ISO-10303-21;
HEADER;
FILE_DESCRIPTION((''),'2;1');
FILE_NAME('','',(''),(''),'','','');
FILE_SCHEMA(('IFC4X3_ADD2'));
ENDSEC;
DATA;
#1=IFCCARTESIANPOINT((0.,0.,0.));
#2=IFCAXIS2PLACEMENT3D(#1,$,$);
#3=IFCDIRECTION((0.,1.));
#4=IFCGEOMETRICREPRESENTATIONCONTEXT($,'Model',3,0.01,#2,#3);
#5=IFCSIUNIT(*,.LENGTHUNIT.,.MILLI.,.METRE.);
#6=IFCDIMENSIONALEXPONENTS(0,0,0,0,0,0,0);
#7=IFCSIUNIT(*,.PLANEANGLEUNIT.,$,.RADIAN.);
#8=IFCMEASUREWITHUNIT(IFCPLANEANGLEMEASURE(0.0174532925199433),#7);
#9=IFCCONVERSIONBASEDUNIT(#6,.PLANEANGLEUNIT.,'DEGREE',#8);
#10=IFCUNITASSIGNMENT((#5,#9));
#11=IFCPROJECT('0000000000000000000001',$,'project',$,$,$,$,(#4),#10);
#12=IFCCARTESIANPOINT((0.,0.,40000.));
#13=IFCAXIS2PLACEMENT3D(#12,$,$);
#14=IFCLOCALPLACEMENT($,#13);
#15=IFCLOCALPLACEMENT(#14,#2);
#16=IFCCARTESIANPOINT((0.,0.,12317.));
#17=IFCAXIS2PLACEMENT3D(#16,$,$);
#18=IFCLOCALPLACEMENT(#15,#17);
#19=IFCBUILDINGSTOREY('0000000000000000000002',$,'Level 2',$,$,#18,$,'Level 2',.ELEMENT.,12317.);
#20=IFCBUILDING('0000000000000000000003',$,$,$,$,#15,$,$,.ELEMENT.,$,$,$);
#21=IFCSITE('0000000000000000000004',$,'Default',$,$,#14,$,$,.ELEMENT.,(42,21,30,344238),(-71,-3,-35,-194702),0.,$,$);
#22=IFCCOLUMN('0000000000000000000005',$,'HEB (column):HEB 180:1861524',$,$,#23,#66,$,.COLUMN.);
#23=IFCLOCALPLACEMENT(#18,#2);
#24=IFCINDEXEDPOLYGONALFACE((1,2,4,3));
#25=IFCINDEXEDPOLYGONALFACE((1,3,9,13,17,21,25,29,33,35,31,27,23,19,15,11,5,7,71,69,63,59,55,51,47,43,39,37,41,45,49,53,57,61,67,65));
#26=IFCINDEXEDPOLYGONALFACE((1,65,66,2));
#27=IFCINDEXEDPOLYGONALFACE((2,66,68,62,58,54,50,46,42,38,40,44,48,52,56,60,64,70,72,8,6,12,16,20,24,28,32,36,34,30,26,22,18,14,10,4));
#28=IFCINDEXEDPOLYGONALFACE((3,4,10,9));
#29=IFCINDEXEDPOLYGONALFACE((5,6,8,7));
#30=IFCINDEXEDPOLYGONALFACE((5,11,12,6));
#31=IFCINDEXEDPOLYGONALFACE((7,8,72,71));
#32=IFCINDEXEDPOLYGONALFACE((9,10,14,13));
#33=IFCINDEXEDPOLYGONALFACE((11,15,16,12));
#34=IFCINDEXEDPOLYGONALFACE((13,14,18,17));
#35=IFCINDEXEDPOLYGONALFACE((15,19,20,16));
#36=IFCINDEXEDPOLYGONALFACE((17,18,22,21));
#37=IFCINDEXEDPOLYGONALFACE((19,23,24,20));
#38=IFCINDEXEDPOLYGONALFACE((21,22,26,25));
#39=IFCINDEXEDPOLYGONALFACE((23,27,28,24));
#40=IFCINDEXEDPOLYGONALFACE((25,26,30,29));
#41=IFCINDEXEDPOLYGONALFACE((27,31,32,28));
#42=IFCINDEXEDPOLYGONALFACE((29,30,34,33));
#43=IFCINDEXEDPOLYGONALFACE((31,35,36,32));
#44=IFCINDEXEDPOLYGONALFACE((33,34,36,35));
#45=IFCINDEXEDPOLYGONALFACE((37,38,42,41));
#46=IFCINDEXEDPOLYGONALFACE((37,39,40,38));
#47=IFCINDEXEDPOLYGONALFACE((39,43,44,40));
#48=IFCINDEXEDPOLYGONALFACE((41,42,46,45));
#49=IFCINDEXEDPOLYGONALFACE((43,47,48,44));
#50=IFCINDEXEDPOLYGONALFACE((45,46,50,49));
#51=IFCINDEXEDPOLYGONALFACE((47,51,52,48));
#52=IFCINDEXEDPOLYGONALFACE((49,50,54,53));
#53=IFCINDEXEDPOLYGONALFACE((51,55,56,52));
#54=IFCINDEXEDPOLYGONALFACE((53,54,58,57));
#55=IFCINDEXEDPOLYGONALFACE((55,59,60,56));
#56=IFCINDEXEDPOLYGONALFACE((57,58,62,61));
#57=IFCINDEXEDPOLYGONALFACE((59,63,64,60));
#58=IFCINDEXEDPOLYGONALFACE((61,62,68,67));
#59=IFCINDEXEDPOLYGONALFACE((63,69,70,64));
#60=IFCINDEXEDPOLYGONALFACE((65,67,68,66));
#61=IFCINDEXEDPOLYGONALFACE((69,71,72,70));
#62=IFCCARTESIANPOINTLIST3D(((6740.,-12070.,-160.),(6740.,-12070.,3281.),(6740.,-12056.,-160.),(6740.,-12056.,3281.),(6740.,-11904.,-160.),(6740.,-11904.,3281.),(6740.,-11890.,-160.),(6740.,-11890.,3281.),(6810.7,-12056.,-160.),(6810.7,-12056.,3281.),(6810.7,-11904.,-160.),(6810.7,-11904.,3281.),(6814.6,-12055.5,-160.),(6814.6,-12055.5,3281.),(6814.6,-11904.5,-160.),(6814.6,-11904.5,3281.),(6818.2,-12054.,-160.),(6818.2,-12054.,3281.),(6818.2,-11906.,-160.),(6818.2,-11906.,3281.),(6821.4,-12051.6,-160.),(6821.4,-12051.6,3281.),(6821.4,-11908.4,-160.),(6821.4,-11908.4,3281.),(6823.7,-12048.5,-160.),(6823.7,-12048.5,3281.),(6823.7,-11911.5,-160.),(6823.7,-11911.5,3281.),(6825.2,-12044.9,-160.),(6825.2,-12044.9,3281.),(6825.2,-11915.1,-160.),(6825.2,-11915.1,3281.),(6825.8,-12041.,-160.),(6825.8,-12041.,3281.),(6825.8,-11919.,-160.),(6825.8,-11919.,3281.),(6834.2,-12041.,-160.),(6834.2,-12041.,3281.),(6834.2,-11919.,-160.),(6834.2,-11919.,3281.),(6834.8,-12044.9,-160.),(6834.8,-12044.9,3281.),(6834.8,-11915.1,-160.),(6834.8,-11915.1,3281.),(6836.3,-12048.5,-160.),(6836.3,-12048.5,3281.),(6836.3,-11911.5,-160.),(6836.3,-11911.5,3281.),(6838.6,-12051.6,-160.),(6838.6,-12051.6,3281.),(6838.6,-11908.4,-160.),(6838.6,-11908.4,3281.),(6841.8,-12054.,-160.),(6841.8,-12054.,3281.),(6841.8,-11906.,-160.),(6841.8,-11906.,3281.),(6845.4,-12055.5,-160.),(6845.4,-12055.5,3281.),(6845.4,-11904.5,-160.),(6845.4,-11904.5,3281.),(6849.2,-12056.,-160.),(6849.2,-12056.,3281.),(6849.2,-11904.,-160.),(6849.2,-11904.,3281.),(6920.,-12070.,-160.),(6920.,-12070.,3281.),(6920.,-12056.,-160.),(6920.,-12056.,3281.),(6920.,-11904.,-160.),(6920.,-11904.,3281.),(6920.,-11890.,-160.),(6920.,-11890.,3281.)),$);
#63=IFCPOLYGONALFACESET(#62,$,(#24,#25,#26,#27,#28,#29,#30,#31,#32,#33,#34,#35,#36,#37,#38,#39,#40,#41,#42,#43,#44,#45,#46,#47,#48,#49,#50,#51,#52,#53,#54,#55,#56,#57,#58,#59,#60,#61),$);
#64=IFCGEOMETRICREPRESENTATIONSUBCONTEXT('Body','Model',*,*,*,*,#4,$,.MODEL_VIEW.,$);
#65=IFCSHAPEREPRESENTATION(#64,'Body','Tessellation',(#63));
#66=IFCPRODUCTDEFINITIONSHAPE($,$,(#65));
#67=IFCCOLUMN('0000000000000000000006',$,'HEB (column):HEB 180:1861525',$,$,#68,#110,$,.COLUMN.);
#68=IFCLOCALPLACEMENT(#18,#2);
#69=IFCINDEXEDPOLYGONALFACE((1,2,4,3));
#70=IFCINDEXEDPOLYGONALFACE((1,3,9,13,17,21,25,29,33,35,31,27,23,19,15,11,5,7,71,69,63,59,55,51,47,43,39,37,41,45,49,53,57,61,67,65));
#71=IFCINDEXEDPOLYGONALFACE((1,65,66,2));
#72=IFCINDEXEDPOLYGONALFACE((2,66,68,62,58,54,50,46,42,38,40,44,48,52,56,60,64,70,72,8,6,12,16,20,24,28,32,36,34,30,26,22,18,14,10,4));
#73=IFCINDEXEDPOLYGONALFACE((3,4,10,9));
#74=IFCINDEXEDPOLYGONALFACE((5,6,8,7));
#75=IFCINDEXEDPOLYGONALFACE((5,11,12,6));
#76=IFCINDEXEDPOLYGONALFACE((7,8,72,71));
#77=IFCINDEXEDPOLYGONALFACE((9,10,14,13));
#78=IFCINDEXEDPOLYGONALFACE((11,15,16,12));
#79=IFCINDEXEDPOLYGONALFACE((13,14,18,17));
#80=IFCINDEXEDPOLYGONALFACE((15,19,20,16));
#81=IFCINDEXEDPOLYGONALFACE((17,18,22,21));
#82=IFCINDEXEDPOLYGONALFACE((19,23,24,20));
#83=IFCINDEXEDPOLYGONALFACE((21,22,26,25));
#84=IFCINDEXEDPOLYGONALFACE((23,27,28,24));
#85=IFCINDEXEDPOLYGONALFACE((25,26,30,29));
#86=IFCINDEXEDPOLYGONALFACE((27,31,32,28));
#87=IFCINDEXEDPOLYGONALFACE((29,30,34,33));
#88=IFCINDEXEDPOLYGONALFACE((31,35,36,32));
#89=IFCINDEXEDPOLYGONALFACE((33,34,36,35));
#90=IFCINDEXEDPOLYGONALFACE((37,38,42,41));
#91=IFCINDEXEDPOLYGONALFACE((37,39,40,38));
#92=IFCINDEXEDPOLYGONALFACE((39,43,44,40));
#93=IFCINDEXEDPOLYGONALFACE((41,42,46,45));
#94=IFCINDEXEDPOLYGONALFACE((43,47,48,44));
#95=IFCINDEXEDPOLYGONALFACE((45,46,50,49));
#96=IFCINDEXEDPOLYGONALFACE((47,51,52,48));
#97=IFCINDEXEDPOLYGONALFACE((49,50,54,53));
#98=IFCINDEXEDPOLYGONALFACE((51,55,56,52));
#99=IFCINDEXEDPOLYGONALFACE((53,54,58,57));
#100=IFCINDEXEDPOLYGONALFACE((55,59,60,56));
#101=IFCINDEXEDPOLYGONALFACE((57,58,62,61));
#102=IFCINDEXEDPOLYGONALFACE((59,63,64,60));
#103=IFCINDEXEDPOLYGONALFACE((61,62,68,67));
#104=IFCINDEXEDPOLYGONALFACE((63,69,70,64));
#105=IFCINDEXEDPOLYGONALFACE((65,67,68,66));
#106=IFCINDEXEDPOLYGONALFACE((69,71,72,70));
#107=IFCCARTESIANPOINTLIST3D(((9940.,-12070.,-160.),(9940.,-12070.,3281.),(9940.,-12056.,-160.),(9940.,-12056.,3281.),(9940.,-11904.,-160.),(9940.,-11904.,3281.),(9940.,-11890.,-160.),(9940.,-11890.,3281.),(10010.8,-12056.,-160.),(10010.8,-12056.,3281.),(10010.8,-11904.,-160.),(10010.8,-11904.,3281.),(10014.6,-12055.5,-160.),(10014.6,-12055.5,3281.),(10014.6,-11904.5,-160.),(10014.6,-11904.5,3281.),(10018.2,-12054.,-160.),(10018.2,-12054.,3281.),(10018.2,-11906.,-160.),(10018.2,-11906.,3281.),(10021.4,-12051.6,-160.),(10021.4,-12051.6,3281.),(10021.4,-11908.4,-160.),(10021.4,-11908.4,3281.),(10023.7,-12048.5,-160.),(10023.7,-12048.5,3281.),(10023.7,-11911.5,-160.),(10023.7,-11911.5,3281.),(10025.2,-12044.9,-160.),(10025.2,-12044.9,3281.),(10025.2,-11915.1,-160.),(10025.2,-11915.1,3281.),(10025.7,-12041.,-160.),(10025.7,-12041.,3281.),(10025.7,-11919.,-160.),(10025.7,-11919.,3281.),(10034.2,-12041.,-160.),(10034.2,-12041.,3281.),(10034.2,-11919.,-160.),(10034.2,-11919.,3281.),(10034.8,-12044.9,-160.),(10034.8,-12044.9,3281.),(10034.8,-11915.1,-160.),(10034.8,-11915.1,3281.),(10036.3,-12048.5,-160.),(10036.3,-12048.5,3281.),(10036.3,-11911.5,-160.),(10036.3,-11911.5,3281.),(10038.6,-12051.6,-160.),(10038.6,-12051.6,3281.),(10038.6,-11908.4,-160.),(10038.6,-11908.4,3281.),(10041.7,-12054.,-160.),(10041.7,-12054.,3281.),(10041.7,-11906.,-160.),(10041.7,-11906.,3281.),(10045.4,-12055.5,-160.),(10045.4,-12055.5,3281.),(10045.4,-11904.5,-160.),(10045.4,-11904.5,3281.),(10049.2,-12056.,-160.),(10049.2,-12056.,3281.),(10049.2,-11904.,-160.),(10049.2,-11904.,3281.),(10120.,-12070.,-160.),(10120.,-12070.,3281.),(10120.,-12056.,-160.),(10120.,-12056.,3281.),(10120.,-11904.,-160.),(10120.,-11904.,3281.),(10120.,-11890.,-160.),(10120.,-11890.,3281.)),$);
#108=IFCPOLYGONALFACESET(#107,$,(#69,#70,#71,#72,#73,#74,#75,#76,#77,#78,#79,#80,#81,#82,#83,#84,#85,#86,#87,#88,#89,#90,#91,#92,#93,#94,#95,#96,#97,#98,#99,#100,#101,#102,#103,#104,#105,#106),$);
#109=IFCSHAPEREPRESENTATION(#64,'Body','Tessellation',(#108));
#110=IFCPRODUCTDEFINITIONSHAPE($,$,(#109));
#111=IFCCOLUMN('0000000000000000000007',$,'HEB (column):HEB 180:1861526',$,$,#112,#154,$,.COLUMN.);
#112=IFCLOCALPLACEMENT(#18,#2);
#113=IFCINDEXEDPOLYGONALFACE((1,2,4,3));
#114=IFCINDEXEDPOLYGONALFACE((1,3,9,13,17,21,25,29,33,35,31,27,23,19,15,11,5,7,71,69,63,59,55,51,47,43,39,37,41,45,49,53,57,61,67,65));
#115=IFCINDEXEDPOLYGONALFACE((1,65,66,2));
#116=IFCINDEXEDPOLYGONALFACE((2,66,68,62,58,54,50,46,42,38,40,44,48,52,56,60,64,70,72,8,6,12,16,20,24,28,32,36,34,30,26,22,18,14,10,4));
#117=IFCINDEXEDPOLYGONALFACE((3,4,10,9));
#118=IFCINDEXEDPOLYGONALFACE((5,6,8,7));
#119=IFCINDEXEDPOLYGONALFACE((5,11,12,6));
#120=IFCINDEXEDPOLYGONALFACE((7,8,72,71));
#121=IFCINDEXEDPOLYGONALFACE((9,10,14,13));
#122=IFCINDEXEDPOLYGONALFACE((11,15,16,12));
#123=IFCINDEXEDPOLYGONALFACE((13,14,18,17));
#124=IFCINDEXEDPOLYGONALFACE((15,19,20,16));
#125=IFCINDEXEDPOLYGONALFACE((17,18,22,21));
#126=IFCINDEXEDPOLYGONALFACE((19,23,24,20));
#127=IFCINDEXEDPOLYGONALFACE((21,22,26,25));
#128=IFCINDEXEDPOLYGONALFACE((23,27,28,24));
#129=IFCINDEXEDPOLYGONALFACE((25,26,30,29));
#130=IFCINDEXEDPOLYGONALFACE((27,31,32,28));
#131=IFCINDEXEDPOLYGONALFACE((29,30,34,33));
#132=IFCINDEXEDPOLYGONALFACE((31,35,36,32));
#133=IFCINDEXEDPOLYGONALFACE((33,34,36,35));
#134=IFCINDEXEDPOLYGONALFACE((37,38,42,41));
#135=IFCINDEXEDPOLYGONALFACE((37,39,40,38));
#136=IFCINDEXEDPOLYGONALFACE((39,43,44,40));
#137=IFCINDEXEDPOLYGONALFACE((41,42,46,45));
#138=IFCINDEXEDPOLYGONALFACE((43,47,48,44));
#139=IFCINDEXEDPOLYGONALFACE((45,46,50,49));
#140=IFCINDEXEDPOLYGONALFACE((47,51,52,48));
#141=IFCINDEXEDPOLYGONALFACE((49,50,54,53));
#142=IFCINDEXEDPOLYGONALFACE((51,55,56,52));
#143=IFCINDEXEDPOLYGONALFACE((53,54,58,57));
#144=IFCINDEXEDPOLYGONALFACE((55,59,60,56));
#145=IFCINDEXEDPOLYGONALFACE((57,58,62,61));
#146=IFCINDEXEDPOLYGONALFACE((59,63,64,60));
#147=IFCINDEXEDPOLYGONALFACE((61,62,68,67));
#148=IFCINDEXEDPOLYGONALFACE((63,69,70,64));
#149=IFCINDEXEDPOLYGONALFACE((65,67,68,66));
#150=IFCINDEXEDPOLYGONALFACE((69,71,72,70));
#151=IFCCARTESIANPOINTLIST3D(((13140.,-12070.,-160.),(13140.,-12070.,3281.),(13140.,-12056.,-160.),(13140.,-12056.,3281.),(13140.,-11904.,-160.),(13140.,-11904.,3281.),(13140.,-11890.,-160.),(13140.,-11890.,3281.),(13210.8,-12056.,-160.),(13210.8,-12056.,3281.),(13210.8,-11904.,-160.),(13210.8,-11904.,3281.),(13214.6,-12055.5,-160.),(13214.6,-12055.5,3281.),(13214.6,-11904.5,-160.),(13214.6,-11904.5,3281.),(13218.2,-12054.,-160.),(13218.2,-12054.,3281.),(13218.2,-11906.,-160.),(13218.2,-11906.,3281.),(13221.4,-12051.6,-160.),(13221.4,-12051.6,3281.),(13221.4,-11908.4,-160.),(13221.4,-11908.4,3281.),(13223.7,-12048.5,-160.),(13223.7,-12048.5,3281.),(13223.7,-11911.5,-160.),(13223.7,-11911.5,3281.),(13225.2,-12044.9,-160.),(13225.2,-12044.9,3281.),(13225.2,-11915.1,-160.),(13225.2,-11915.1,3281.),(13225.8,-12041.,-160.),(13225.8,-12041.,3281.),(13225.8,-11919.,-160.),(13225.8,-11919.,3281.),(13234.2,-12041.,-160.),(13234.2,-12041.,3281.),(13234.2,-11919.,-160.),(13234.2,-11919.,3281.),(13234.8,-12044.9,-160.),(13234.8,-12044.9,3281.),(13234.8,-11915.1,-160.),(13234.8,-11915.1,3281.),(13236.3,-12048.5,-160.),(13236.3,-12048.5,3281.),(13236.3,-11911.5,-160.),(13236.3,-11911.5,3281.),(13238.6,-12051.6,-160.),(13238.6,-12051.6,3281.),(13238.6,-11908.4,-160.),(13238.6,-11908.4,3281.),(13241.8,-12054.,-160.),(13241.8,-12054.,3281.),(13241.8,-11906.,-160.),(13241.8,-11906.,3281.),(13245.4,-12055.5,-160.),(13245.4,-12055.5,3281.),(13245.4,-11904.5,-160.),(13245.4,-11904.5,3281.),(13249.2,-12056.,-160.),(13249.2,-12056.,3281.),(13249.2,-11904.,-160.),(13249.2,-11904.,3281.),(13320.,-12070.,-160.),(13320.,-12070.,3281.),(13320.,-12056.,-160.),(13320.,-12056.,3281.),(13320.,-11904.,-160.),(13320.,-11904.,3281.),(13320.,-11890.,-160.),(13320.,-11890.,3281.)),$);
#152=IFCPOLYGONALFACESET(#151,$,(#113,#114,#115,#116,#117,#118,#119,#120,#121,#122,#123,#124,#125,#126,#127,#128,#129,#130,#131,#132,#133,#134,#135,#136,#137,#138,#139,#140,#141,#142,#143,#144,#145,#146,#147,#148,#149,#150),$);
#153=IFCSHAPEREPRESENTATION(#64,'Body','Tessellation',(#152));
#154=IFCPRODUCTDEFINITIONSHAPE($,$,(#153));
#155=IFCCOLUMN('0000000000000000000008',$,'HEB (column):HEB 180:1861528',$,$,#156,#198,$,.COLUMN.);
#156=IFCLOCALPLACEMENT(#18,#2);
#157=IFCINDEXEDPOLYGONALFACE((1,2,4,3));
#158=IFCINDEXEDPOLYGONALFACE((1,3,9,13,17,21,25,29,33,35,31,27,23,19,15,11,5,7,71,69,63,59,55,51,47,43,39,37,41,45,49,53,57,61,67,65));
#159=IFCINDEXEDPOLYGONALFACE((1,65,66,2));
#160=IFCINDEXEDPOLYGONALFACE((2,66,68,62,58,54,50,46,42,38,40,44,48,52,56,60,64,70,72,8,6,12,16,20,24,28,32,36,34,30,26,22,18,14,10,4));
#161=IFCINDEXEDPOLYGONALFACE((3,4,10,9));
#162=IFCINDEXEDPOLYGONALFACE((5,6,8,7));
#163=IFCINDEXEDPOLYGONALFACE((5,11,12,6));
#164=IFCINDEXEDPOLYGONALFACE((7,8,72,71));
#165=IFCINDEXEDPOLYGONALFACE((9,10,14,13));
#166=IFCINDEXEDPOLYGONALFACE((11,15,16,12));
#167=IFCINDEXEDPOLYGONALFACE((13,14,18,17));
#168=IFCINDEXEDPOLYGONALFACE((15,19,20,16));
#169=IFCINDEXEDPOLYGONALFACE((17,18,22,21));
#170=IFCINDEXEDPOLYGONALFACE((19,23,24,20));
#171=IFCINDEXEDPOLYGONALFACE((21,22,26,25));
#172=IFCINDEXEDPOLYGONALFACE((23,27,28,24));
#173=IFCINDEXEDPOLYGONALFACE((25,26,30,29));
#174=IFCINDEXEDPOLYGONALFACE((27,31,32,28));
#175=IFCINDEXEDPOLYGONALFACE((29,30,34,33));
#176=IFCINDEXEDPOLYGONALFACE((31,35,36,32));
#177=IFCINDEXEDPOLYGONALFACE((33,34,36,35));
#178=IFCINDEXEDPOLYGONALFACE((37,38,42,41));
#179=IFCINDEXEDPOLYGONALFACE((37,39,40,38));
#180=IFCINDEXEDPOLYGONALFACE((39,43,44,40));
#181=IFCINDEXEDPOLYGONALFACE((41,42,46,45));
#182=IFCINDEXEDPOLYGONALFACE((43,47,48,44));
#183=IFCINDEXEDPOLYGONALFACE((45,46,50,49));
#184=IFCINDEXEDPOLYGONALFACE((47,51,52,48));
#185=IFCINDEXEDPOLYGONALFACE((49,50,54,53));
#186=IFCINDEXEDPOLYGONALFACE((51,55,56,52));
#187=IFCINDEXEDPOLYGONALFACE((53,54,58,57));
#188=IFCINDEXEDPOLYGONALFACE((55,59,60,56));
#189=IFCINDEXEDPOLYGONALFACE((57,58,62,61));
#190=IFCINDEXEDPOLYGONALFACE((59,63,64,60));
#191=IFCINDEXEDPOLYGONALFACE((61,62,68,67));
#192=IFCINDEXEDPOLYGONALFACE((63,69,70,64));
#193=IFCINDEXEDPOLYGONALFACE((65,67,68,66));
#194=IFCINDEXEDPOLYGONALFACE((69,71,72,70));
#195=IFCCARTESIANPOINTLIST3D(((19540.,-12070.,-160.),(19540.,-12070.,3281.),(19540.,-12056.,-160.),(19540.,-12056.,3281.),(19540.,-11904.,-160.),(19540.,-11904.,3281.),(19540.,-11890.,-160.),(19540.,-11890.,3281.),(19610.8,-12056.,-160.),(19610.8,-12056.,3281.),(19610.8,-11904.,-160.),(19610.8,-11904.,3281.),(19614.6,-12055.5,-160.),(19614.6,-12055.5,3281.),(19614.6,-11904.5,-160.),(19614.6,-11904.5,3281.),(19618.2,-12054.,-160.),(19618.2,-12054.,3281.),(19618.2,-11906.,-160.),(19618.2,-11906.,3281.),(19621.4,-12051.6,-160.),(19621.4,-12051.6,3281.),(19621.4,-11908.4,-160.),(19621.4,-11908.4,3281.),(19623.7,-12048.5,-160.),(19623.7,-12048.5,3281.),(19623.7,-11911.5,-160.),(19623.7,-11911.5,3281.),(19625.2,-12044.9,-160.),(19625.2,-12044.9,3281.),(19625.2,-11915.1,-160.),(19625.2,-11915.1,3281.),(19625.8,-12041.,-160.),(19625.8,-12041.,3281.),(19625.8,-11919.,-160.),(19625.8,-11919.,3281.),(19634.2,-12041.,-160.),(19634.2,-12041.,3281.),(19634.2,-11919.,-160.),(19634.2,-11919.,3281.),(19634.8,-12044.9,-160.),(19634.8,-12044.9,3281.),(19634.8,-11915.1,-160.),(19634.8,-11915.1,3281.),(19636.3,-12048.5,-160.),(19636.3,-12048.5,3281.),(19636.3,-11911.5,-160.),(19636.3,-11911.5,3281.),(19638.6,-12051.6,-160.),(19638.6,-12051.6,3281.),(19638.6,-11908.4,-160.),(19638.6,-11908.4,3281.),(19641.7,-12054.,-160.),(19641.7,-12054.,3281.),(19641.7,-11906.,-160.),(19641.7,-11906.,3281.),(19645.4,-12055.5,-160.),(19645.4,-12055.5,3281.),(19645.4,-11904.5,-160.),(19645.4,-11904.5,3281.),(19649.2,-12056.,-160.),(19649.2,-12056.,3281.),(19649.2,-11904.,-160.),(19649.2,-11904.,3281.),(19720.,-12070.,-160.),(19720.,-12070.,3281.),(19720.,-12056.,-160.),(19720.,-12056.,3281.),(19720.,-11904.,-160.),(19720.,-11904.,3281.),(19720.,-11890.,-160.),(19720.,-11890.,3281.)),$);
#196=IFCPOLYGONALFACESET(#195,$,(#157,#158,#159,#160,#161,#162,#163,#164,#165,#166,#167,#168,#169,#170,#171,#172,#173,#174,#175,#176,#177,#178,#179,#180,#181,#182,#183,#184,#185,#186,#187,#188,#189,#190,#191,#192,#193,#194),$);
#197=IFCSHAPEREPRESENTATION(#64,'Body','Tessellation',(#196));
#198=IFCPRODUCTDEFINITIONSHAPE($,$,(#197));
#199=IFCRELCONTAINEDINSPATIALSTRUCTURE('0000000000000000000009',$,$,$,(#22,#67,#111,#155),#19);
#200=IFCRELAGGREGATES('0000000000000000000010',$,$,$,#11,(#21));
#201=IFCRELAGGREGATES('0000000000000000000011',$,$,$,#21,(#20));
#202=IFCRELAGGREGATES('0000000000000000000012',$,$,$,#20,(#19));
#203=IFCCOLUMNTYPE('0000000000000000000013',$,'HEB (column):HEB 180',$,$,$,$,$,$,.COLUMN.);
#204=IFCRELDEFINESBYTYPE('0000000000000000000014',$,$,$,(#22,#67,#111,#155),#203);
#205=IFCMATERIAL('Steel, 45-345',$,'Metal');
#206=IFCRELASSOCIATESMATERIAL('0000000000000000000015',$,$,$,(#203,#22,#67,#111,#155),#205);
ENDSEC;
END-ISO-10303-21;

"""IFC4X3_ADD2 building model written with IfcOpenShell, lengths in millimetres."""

from ifc_helpers import new_model, entity, si_unit, converted_unit, direction, frame, origin, origin_2d_with_axis, place, context, subcontext, project, spatial, i_section, extrude, source, transform, mapped, material, material_profile, profile_set, profile_usage, type_object, type_shapes, element, save


model = new_model("IFC4X3_ADD2")

# Units and contexts
model_context = context("Model", 3, precision=0.01, world=origin(), true_north=direction((0.0, 1.0)))
body_context = subcontext(model_context, "Body", "Model", "MODEL_VIEW")
ifc_project = project(units=[si_unit("LENGTHUNIT", "METRE", prefix="MILLI"), converted_unit("PLANEANGLEUNIT", "DEGREE", entity("IfcPlaneAngleMeasure", 0.0174532925199433), si_unit("PLANEANGLEUNIT", "RADIAN"), dimensions=[0, 0, 0, 0, 0, 0, 0])], contexts=[model_context])

# Site, building, storey
site_placement = place(None, frame((0.0, 0.0, 40000.0)))
site = spatial("IfcSite", under=ifc_project, at=site_placement, Name="Default", CompositionType="ELEMENT", RefLatitude=(42, 21, 30, 344238), RefLongitude=(-71, -3, -35, -194702), RefElevation=0.0)
building_placement = place(site_placement, origin())
building = spatial("IfcBuilding", under=site, at=building_placement, CompositionType="ELEMENT")
storey_placement = place(building_placement, frame((0.0, 0.0, 12317.0)))
storey = spatial("IfcBuildingStorey", under=building, at=storey_placement, Name="Level 2", LongName="Level 2", CompositionType="ELEMENT", Elevation=12317.0)

# Columns
ifc_material_1 = material(Name="Steel, 45-345", Category="Metal")
ifc_material_profile_1 = material_profile(ifc_material_1, i_section(OverallWidth=180.0, OverallDepth=180.0, WebThickness=8.5, FlangeThickness=14.0, FilletRadius=15.0, at=origin_2d_with_axis()), Name="HEB 180")
ifc_profile_set_1 = profile_set([ifc_material_profile_1], Name="HEB 180")
ifc_profile_usage_1 = profile_usage(ifc_profile_set_1)
column_type = type_object("IfcColumnType", Name="HEB (column):HEB 180", PredefinedType="COLUMN", material=ifc_profile_set_1)
shared_shape_1 = source(origin(), body_context, "Body", "SweptSolid", [
    extrude(i_section(OverallWidth=180.0, OverallDepth=180.0, WebThickness=8.5, FlangeThickness=14.0, FilletRadius=15.0, at=origin_2d_with_axis()), frame((0.0, 0.0, 12157.0), z_axis=(0.0, 0.0, 1.0), x_axis=(-1.0, 0.0, 0.0)), (0.0, 0.0, 1.0), 3441.0),
])
type_shapes(column_type, [shared_shape_1])
for number, where, name in (
    (1, (6830.0, -11980.0, -12317.0), "HEB (column):HEB 180:1861524"),
    (2, (10030.0, -11980.0, -12317.0), "HEB (column):HEB 180:1861525"),
):
    element("IfcColumn", number, at=place(storey_placement, frame(where)), inside=storey, type_object=column_type, material=ifc_profile_usage_1, Name=name, PredefinedType="COLUMN", context=body_context, shape_type="MappedRepresentation", body=[
        mapped(shared_shape_1, transform((0.0, 0.0, 0.0), scale=1.0)),
    ])
column_1_placement = place(storey_placement, frame((13230.0, -11980.0, -12317.0), z_axis=(0.0, 0.0, 1.0), x_axis=(-1.0, 0.0, 0.0)))
element("IfcColumn", 3, at=column_1_placement, inside=storey, type_object=column_type, material=ifc_profile_usage_1, Name="HEB (column):HEB 180:1861526", PredefinedType="COLUMN", context=body_context, shape_type="MappedRepresentation", body=[
    mapped(shared_shape_1, transform((0.0, 0.0, 0.0), scale=1.0)),
])
for number, where, name in (
    (4, (19630.0, -11980.0, -12317.0), "HEB (column):HEB 180:1861528"),
):
    element("IfcColumn", number, at=place(storey_placement, frame(where)), inside=storey, type_object=column_type, material=ifc_profile_usage_1, Name=name, PredefinedType="COLUMN", context=body_context, shape_type="MappedRepresentation", body=[
        mapped(shared_shape_1, transform((0.0, 0.0, 0.0), scale=1.0)),
    ])

save(model, "model.ifc")
